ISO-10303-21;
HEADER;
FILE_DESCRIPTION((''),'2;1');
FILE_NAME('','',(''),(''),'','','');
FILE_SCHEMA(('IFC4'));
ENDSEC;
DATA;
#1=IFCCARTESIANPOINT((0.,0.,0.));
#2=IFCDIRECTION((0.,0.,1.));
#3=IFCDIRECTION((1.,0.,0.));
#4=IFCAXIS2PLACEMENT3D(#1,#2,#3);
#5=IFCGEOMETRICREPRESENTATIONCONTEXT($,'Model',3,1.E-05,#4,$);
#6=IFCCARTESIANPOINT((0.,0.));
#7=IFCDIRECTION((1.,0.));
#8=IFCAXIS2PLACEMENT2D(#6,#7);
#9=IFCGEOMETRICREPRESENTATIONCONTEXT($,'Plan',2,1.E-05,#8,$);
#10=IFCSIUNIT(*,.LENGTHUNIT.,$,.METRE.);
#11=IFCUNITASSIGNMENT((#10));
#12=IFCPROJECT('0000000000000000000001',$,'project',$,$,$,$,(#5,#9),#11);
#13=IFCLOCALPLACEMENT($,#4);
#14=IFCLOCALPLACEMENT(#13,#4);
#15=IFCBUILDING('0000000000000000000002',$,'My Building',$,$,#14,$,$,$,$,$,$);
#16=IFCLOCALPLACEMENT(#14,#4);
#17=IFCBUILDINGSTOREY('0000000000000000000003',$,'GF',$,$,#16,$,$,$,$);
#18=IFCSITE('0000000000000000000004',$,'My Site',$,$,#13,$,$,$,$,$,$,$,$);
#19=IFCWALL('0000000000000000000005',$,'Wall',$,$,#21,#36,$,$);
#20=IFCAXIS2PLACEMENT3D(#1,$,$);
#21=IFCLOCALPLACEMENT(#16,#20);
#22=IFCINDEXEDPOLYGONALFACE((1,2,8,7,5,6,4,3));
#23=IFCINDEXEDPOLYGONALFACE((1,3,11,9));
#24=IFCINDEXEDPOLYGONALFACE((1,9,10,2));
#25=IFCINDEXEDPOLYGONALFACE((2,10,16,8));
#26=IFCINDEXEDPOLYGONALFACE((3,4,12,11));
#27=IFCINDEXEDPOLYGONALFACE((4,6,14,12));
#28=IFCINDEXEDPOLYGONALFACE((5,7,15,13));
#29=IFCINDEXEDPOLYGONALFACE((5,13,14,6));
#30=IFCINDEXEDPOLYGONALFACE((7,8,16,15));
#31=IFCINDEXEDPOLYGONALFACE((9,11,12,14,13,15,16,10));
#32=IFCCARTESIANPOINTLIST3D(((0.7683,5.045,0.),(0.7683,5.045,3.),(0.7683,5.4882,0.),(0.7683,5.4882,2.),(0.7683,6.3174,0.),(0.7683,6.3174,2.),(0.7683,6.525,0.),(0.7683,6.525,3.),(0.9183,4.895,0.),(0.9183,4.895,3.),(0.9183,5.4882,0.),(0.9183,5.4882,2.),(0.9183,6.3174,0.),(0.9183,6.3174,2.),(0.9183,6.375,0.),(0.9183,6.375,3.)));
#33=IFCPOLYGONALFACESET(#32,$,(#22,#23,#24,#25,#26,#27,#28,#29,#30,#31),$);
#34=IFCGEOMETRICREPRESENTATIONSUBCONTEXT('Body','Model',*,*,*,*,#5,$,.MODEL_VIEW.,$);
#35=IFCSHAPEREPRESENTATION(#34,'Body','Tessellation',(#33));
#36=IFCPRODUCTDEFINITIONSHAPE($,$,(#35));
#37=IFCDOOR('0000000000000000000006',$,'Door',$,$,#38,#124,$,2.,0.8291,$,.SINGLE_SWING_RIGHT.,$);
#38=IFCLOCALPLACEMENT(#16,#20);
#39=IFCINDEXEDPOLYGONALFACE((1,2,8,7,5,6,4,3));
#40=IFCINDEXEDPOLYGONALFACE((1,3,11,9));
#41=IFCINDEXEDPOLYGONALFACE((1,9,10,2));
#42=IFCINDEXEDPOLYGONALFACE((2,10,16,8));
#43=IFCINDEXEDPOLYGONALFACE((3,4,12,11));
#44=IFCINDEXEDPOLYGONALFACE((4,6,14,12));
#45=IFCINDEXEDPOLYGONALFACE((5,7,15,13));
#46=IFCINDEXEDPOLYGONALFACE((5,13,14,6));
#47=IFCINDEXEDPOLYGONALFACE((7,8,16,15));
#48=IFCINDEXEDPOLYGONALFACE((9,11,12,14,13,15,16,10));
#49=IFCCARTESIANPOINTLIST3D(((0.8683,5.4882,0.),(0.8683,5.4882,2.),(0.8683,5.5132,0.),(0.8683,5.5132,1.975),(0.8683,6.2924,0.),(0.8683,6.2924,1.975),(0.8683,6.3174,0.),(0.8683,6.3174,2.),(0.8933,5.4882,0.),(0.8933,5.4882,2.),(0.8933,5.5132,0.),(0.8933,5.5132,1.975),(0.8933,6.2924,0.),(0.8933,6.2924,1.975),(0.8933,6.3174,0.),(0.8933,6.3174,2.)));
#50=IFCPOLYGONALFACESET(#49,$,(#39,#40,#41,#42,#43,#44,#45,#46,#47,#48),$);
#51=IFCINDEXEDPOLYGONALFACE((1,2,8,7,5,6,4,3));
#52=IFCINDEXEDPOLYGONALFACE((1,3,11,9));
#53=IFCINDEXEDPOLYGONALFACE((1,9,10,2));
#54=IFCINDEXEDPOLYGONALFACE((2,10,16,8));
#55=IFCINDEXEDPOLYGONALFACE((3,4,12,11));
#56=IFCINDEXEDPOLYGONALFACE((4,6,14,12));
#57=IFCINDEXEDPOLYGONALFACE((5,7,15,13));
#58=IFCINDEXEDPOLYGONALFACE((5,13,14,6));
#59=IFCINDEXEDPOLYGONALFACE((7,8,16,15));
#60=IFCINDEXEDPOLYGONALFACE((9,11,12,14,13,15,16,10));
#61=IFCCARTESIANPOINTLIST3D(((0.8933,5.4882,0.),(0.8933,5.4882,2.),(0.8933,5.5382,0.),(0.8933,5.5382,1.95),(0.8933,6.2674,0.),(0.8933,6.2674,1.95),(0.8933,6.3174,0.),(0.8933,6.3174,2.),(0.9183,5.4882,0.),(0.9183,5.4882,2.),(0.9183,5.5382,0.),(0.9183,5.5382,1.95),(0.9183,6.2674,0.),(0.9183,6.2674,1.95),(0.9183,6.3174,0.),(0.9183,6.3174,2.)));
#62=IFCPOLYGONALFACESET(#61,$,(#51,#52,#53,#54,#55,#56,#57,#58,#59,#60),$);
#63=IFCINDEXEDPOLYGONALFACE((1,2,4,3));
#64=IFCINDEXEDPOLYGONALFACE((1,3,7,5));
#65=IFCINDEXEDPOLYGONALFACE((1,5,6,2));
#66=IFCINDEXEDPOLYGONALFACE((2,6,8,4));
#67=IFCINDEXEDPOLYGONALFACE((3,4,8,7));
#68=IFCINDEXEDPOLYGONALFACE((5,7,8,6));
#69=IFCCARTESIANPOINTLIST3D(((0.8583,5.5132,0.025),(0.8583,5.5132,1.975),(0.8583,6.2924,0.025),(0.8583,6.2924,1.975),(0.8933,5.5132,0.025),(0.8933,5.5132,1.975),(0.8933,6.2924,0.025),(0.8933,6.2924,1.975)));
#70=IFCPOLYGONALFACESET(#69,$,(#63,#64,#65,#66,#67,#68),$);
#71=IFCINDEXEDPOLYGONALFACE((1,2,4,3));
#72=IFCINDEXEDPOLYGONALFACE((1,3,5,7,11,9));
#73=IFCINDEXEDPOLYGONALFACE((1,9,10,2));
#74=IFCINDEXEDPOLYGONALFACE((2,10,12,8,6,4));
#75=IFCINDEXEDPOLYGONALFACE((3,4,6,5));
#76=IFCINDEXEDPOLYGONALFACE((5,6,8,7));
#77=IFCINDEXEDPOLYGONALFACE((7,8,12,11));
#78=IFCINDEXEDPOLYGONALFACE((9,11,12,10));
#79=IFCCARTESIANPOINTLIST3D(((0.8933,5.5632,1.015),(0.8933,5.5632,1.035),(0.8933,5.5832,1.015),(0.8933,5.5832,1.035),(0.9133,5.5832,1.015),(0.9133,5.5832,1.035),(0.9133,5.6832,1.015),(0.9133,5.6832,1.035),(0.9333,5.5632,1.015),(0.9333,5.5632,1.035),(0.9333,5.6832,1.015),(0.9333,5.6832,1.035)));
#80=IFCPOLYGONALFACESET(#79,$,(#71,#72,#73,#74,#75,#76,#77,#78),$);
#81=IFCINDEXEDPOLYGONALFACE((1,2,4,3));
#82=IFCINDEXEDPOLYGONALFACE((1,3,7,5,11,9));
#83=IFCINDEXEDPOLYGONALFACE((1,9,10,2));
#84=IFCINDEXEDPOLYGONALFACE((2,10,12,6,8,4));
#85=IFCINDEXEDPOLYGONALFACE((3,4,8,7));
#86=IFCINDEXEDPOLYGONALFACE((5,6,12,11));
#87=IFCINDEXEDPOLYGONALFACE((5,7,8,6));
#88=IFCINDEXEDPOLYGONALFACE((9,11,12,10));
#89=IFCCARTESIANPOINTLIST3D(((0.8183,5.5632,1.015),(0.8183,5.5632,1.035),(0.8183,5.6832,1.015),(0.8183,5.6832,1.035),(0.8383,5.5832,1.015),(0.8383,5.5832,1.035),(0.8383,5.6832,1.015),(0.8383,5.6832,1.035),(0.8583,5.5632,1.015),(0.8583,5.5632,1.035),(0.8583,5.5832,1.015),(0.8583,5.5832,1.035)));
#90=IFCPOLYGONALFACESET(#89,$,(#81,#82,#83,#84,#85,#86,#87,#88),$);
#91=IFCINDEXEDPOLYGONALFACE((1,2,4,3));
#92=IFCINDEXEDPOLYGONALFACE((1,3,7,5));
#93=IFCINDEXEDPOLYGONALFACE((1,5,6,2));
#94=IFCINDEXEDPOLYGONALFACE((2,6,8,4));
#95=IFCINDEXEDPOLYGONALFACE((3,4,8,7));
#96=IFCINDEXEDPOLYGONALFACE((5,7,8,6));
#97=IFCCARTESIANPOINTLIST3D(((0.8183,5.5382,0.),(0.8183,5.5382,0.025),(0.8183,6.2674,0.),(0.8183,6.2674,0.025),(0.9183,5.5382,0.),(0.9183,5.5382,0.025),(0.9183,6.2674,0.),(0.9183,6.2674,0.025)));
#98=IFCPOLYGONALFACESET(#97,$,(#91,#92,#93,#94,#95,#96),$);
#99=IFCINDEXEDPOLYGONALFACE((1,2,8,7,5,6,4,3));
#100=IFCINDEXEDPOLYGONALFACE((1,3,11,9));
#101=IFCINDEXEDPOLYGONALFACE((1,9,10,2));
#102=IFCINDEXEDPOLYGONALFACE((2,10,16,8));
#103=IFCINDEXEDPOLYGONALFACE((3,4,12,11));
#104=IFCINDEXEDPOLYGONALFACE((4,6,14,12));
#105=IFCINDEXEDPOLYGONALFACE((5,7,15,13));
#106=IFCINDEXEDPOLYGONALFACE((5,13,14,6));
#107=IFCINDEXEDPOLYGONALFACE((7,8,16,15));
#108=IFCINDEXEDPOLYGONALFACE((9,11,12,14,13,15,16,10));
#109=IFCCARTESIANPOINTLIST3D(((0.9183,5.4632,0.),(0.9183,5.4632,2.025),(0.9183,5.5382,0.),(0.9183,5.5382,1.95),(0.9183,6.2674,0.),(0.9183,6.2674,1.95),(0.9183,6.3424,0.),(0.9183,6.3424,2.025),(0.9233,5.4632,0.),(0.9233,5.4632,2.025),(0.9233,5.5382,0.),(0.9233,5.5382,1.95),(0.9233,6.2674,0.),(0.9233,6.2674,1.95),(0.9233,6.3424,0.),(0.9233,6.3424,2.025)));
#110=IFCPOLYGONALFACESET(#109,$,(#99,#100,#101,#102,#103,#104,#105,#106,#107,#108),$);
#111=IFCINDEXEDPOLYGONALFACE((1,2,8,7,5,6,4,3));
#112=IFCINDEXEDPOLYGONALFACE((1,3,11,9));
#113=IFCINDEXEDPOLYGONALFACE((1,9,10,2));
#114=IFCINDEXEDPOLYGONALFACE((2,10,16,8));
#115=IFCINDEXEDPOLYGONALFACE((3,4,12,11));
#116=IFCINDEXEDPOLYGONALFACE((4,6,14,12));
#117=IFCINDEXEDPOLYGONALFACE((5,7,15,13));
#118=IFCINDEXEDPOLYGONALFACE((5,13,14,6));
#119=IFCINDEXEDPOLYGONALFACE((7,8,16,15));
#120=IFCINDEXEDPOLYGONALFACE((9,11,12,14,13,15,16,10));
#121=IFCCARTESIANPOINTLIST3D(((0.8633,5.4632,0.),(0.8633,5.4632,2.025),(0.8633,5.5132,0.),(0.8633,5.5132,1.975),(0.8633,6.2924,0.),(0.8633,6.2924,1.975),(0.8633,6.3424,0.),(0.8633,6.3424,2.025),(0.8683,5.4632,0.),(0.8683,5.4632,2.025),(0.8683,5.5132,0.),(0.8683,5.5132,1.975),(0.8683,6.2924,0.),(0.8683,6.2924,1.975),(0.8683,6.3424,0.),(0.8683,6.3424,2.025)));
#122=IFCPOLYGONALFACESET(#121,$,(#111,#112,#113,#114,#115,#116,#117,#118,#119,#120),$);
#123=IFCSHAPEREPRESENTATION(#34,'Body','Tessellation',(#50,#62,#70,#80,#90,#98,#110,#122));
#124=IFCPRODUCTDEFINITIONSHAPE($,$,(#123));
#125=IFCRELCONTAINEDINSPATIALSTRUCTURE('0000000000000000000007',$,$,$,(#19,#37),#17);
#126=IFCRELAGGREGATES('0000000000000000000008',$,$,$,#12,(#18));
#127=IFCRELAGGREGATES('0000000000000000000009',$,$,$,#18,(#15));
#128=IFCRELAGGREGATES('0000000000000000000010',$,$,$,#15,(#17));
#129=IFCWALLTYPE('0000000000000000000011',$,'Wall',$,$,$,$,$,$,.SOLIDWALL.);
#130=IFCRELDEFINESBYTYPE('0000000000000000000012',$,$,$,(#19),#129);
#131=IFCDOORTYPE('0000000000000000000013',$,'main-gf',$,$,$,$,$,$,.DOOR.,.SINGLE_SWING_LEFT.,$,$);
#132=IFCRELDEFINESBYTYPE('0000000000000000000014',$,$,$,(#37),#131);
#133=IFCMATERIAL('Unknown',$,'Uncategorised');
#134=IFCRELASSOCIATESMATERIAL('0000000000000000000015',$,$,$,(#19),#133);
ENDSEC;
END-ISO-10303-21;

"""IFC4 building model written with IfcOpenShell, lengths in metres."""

from ifc_helpers import new_model, entity, si_unit, frame, origin_with_axes, origin_2d_with_axis, place, context, subcontext, project, spatial, line, indexed_curve, outline, extrude, shape, source, transform, mapped, material, type_object, type_shapes, element, fill, save


model = new_model("IFC4")

# Units and contexts
model_context = context("Model", 3, precision=1e-05, world=origin_with_axes())
plan_context = context("Plan", 2, precision=1e-05, world=origin_2d_with_axis())
body_context_1 = subcontext(model_context, "Body", "Model", "MODEL_VIEW")
body_context_2 = subcontext(plan_context, "Body", "Plan", "PLAN_VIEW")
ifc_project = project(units=[si_unit("LENGTHUNIT", "METRE")], contexts=[model_context, plan_context])

# Site, building, storey
site_placement = place(None, origin_with_axes())
site = spatial("IfcSite", under=ifc_project, at=site_placement, Name="My Site")
building_placement = place(site_placement, origin_with_axes())
building = spatial("IfcBuilding", under=site, at=building_placement, Name="My Building")
storey_placement = place(building_placement, origin_with_axes())
storey = spatial("IfcBuildingStorey", under=building, at=storey_placement, Name="GF")

# Shared definitions
ifc_material = material(Name="Unknown", Category="Uncategorised")

# Shared definitions
wall_type_1 = type_object("IfcWallType", Name="Wall", PredefinedType="SOLIDWALL")
shared_shape_1 = source(origin_with_axes(), body_context_1, "Body", "SweptSolid", [
    extrude(outline(indexed_curve([(0.0, 0.0), (0.8291, 0.0), (0.8291, 2.0), (0.0, 2.0)], segments=[line(1, 2, 3, 4, 1)])), frame((0.0, -0.6, 0.0), z_axis=(0.0, -1.0, 0.0), x_axis=(1.0, 0.0, 0.0)), (0.0, 0.0, -1.0), 1.2),
])
door_type_1 = type_object("IfcDoorType", Name="main-gf", OperationType="SINGLE_SWING_LEFT", PredefinedType="DOOR")
shared_shape_2 = source(origin_with_axes(), body_context_1, "Body", "SweptSolid", [
    extrude(outline(indexed_curve([(0.0, 0.0), (0.0, 2.0), (0.8291, 2.0), (0.8291, 0.0), (0.8041, 0.0), (0.8041, 1.975), (0.025, 1.975), (0.025, 0.0)], segments=[line(1, 2, 3, 4, 5, 6, 7, 8, 1)])), frame((0.0, 0.025, 0.0), z_axis=(0.0, -1.0, 0.0), x_axis=(1.0, 0.0, 0.0)), (0.0, 0.0, -1.0), 0.025),
    extrude(outline(indexed_curve([(0.0, 0.0), (0.0, 2.0), (0.8291, 2.0), (0.8291, 0.0), (0.7791, 0.0), (0.7791, 1.95), (0.05, 1.95), (0.05, 0.0)], segments=[line(1, 2, 3, 4, 5, 6, 7, 8, 1)])), frame((0.0, 0.0, 0.0), z_axis=(0.0, -1.0, 0.0), x_axis=(1.0, 0.0, 0.0)), (0.0, 0.0, -1.0), 0.025),
    extrude(outline(indexed_curve([(0.0, 0.0), (0.7791, 0.0), (0.7791, 0.035), (0.0, 0.035)], segments=[line(1, 2, 3, 4, 1)])), frame((0.025, 0.025, 0.025), z_axis=(0.0, 0.0, 1.0), x_axis=(1.0, 0.0, 0.0)), (0.0, 0.0, 1.0), 1.95),
    extrude(outline(indexed_curve([(0.0, 0.0), (0.0, -0.04), (0.12, -0.04), (0.12, -0.02), (0.02, -0.02), (0.02, 0.0)], segments=[line(1, 2, 3, 4, 5, 6, 1)])), frame((0.075, 0.025, 1.015), z_axis=(0.0, 0.0, 1.0), x_axis=(1.0, 0.0, 0.0)), (0.0, 0.0, 1.0), 0.02),
    extrude(outline(indexed_curve([(0.0, 0.0), (0.0, 0.04), (0.12, 0.04), (0.12, 0.02), (0.02, 0.02), (0.02, 0.0)], segments=[line(1, 2, 3, 4, 5, 6, 1)])), frame((0.075, 0.06, 1.015), z_axis=(0.0, 0.0, 1.0), x_axis=(1.0, 0.0, 0.0)), (0.0, 0.0, 1.0), 0.02),
    extrude(outline(indexed_curve([(0.0, 0.0), (0.7291, 0.0), (0.7291, 0.1), (0.0, 0.1)], segments=[line(1, 2, 3, 4, 1)])), frame((0.05, 0.0, 0.0), z_axis=(0.0, 0.0, 1.0), x_axis=(1.0, 0.0, 0.0)), (0.0, 0.0, 1.0), 0.025),
    extrude(outline(indexed_curve([(0.0, 0.0), (0.0, 2.025), (0.8791, 2.025), (0.8791, 0.0), (0.8041, 0.0), (0.8041, 1.95), (0.075, 1.95), (0.075, 0.0)], segments=[line(1, 2, 3, 4, 5, 6, 7, 8, 1)])), frame((-0.025, -0.005, 0.0), z_axis=(0.0, -1.0, 0.0), x_axis=(1.0, 0.0, 0.0)), (0.0, 0.0, -1.0), 0.005),
    extrude(outline(indexed_curve([(0.0, 0.0), (0.0, 2.025), (0.8791, 2.025), (0.8791, 0.0), (0.8291, 0.0), (0.8291, 1.975), (0.05, 1.975), (0.05, 0.0)], segments=[line(1, 2, 3, 4, 5, 6, 7, 8, 1)])), frame((-0.025, 0.05, 0.0), z_axis=(0.0, -1.0, 0.0), x_axis=(1.0, 0.0, 0.0)), (0.0, 0.0, -1.0), 0.005),
])
shared_shape_3 = source(origin_with_axes(), body_context_2, "Body", "Curve2D", [
    entity("IfcIndexedPolyCurve", entity("IfcCartesianPointList2D", [[0.0, 0.0], [0.0, 0.05], [0.025, 0.05], [0.025, 0.025], [0.05, 0.025], [0.05, 0.0]]), [entity("IfcLineIndex", [1, 2, 3, 4, 5, 6, 1])]),
    entity("IfcIndexedPolyCurve", entity("IfcCartesianPointList2D", [[0.8291, 0.0], [0.8291, 0.05], [0.8041, 0.05], [0.8041, 0.025], [0.7791, 0.025], [0.7791, 0.0]]), [entity("IfcLineIndex", [1, 2, 3, 4, 5, 6, 1])]),
    entity("IfcTrimmedCurve", entity("IfcEllipse", entity("IfcAxis2Placement2D", entity("IfcCartesianPoint", [0.7691, 0.05]), entity("IfcDirection", [1.0, 0.0])), 0.7441, 0.7791), [entity("IfcCartesianPoint", [0.7691, 0.8291])], [entity("IfcCartesianPoint", [0.025, 0.05])], True, "CARTESIAN"),
    entity("IfcIndexedPolyCurve", entity("IfcCartesianPointList2D", [[0.8041, 0.05], [0.7691, 0.05], [0.7691, 0.8291], [0.8041, 0.8291]]), [entity("IfcLineIndex", [1, 2, 3, 4, 1])]),
])
type_shapes(door_type_1, [shared_shape_2, shared_shape_3])

# Wall, opening, door
wall_1_placement = place(storey_placement, frame((0.7683, 6.525, 0.0), z_axis=(0.0, 0.0, 1.0), x_axis=(0.0, -1.0, 0.0)))
wall_1 = element("IfcWall", 1, at=wall_1_placement, inside=storey, type_object=wall_type_1, material=ifc_material, Name="Wall", context=body_context_1, shape_type="SweptSolid", body=[
    extrude(outline(indexed_curve([(0.0, 0.0), (0.15, 0.15), (1.63, 0.15), (1.48, 0.0)], segments=[line(1, 2, 3, 4, 1)])), origin_with_axes(), (0.0, 0.0, 1.0), 3.0),
])
opening_1_placement = place(wall_1_placement, frame((1.0368, 0.15, 0.0), z_axis=(0.0, 0.0, 1.0), x_axis=(-1.0, 0.0, 0.0)))
opening_1 = element("IfcOpeningElement", 2, at=opening_1_placement, cuts=wall_1, PredefinedType="OPENING", context=body_context_1, shape_type="MappedRepresentation", body=[
    mapped(shared_shape_1, transform((0.0, 0.0, 0.0), x_axis=(1.0, 0.0, 0.0), y_axis=(0.0, 1.0, 0.0), z_axis=(0.0, 0.0, 1.0), scale=1.0)),
])
door_1_placement = place(opening_1_placement, frame((0.0, 0.0, 0.0), z_axis=(0.0, 0.0, 1.0), x_axis=(1.0, 0.0, 0.0)))
door_1 = element("IfcDoor", 3, at=door_1_placement, inside=storey, type_object=door_type_1, Name="Door", OperationType="SINGLE_SWING_RIGHT", OverallHeight=2.0, OverallWidth=0.8291, shapes=[
    shape(body_context_1, "Body", "MappedRepresentation", [mapped(shared_shape_2, transform((0.0, 0.0, 0.0), x_axis=(1.0, 0.0, 0.0), y_axis=(0.0, 1.0, 0.0), z_axis=(0.0, 0.0, 1.0), scale=1.0))]),
    shape(body_context_2, "Body", "MappedRepresentation", [mapped(shared_shape_3, transform((0.0, 0.0, 0.0), x_axis=(1.0, 0.0, 0.0), y_axis=(0.0, 1.0, 0.0), z_axis=(0.0, 0.0, 1.0), scale=1.0))]),
])
fill(opening_1, door_1)

save(model, "model.ifc")
